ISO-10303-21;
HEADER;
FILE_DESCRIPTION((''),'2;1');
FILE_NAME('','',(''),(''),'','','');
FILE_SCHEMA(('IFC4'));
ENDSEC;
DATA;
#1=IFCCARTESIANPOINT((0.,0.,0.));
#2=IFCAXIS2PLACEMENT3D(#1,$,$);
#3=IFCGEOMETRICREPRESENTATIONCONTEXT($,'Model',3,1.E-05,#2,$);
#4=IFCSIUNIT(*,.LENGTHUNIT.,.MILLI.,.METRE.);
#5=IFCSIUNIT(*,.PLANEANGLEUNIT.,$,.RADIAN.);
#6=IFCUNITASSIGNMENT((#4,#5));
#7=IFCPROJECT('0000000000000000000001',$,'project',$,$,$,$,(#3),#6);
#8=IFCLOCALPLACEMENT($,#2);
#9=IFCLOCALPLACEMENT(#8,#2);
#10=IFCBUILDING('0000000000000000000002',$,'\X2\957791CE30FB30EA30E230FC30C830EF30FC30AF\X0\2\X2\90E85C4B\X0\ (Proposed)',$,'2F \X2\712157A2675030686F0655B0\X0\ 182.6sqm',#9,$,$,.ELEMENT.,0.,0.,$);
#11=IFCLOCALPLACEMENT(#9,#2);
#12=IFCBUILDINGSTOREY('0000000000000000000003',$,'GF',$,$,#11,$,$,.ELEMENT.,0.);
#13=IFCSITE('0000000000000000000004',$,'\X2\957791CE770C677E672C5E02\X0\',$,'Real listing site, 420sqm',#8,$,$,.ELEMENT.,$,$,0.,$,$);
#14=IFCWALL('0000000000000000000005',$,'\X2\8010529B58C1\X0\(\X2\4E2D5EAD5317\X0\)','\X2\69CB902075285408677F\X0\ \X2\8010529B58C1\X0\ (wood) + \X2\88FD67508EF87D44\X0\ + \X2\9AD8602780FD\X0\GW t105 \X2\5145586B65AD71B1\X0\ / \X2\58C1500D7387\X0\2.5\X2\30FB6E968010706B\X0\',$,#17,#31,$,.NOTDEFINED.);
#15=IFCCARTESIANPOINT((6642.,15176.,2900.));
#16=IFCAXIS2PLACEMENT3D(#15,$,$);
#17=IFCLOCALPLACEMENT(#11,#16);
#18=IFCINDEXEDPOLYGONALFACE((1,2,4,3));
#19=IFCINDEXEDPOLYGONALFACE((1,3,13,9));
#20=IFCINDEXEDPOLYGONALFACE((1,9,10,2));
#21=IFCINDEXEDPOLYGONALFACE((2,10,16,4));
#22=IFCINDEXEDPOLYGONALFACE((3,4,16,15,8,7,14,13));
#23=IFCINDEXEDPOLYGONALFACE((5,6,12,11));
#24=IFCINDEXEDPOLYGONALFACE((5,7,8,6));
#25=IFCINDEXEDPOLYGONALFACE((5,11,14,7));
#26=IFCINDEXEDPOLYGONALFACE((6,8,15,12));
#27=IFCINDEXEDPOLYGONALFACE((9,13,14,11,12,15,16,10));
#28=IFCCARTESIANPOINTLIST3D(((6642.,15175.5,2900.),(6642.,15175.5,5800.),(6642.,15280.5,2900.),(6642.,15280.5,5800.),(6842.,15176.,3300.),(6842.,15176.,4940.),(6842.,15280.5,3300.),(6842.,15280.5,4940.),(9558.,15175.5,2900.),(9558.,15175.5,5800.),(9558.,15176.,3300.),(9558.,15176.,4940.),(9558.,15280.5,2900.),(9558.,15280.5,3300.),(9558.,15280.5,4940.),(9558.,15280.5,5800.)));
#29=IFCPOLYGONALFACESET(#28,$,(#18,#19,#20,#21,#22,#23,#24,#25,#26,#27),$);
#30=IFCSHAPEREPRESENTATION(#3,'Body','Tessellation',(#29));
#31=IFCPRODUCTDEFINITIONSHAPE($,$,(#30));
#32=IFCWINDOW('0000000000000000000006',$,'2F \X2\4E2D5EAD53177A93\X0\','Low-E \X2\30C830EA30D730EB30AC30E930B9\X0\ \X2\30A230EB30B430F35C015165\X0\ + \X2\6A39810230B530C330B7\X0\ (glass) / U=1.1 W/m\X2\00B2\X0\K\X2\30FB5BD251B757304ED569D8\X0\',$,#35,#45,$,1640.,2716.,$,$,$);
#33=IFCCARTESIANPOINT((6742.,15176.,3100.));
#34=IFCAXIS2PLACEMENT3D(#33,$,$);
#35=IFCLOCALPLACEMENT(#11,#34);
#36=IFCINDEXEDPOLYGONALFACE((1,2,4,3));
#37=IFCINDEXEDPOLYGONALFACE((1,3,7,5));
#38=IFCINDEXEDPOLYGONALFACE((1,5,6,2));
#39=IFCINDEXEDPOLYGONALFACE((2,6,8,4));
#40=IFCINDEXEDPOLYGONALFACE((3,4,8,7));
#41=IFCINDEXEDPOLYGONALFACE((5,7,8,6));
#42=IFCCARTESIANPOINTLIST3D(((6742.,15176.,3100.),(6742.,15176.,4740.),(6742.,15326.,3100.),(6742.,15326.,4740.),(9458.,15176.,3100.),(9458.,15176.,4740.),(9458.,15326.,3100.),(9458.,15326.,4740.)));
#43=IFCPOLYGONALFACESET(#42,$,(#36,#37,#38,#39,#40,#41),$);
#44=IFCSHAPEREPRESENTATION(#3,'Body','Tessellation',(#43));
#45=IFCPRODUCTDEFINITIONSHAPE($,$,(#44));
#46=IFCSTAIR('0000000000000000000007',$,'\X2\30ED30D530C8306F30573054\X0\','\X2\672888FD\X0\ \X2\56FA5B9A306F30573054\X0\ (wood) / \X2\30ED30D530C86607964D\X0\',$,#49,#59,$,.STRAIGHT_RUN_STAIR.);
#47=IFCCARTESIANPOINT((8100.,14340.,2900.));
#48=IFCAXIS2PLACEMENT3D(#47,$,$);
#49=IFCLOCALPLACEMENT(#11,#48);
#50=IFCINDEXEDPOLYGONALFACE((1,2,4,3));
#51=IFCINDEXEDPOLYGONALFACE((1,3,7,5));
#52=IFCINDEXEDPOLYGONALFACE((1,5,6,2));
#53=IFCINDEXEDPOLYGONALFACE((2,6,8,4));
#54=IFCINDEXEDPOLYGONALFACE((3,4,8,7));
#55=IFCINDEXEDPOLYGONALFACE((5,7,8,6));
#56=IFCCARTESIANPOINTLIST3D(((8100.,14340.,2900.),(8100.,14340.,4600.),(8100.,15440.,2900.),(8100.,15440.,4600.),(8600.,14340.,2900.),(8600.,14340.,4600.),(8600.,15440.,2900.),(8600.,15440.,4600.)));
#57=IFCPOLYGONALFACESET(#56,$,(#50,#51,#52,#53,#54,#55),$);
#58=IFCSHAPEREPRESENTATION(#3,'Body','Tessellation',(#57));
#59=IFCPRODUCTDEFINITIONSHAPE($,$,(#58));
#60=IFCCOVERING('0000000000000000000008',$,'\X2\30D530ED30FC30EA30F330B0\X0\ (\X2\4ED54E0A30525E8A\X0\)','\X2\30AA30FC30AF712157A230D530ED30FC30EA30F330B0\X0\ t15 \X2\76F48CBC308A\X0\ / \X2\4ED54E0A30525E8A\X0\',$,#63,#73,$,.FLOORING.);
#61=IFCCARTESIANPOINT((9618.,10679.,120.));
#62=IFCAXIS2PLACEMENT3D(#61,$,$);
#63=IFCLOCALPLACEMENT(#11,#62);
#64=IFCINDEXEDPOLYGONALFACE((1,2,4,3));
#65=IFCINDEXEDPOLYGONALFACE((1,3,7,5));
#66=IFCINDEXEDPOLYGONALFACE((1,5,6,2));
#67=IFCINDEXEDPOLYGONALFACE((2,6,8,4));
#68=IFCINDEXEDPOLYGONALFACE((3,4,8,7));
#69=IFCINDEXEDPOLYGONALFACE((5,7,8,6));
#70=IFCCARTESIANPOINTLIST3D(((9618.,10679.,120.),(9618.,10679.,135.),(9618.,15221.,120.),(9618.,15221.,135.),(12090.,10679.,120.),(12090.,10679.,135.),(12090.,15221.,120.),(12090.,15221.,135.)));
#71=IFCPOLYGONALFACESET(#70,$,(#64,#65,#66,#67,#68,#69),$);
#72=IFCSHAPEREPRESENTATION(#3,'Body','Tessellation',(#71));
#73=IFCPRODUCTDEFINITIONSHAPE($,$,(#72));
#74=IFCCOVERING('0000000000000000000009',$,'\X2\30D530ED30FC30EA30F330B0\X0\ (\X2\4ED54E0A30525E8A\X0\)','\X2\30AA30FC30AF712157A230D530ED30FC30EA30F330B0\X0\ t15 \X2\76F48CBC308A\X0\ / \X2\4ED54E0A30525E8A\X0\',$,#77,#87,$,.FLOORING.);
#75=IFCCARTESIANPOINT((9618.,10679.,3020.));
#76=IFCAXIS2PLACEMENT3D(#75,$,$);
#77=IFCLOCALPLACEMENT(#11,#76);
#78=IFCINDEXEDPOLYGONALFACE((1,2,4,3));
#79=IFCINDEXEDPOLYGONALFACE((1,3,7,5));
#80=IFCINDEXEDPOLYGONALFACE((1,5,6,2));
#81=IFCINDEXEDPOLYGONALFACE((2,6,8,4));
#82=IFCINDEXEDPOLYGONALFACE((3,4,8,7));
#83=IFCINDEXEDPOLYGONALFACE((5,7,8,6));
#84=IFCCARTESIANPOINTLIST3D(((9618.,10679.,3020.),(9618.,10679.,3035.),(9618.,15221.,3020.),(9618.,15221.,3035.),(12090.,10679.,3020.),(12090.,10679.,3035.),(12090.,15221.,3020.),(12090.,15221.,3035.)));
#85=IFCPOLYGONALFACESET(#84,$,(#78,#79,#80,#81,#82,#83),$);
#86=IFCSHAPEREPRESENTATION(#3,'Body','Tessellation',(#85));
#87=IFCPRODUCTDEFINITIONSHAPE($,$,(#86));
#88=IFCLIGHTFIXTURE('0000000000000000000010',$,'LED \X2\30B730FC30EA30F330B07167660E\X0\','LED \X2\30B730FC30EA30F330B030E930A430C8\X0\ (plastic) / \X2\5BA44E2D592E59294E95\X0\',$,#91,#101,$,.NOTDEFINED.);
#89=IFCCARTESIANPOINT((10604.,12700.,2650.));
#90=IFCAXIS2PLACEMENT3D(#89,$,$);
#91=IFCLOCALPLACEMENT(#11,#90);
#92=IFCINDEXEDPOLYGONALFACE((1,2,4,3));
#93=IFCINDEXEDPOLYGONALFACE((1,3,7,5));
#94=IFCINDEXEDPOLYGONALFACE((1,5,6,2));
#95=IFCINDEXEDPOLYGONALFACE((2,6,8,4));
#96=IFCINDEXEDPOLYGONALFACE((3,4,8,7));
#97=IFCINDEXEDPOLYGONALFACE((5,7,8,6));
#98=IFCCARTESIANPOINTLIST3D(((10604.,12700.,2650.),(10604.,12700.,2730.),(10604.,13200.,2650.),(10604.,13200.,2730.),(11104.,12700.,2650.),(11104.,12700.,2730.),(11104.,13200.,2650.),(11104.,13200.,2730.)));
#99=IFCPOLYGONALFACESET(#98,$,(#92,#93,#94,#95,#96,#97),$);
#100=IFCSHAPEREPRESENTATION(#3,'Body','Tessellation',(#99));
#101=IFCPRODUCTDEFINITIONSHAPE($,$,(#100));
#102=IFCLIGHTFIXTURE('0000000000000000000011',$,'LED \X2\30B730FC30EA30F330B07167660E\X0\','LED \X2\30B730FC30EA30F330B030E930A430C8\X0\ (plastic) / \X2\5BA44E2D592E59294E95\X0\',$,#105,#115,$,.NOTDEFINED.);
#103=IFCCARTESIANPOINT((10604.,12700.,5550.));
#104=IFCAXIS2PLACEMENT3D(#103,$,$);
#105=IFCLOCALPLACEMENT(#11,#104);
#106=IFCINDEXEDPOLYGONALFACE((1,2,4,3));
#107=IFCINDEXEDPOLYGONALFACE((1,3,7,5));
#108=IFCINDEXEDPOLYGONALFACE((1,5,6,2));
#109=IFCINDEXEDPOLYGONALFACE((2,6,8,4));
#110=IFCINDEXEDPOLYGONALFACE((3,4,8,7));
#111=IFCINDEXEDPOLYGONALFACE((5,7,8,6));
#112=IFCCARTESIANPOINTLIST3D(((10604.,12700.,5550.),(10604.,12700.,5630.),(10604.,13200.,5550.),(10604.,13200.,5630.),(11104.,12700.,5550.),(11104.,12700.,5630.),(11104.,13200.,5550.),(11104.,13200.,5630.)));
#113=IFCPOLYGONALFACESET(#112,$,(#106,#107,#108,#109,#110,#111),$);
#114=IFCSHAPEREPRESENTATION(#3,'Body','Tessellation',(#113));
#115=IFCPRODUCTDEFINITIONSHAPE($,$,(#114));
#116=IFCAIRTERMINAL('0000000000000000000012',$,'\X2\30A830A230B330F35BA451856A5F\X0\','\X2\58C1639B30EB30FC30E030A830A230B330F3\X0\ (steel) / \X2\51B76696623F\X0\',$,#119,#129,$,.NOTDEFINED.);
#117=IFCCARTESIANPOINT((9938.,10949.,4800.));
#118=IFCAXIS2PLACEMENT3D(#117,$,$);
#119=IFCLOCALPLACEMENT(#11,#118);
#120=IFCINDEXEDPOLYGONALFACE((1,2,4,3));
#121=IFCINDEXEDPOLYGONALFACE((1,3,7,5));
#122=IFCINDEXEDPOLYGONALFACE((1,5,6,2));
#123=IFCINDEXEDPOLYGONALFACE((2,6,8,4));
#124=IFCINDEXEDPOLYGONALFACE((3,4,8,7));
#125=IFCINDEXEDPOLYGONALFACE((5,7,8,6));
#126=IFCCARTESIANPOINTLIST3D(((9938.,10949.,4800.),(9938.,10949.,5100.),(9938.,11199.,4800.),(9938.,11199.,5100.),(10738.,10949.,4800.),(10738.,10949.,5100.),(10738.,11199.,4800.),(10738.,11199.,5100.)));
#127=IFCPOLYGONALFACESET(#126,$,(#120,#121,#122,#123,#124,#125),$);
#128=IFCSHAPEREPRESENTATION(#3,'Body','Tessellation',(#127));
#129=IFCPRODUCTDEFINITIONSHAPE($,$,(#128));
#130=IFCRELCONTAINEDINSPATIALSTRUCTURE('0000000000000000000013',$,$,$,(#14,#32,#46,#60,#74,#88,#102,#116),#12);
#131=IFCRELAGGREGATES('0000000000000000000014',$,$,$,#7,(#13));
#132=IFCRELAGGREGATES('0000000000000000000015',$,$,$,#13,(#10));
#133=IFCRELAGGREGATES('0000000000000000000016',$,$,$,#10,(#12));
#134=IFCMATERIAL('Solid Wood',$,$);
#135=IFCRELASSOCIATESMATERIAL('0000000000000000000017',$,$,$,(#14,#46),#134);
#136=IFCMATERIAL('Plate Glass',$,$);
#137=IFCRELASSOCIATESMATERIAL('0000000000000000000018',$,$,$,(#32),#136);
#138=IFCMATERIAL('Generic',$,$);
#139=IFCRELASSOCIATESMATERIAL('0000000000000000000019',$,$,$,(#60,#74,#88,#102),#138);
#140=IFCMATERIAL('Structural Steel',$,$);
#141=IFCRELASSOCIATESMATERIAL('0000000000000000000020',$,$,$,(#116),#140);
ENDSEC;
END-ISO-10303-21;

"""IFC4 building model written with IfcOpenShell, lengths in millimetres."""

from ifc_helpers import new_model, si_unit, frame, frame_2d, origin, place, context, project, spatial, rectangle, extrude, material, element, fill, save


model = new_model("IFC4")

# Units and contexts
model_context = context("Model", 3, precision=1e-05, world=origin())
ifc_project = project(units=[si_unit("LENGTHUNIT", "METRE", prefix="MILLI"), si_unit("PLANEANGLEUNIT", "RADIAN")], contexts=[model_context])

# Site, building, storey
site_placement = place(None, origin())
site = spatial("IfcSite", under=ifc_project, at=site_placement, Name="長野県松本市", ObjectType="Real listing site, 420sqm", CompositionType="ELEMENT", RefElevation=0.0)
building_placement = place(site_placement, origin())
building = spatial("IfcBuilding", under=site, at=building_placement, Name="長野・リモートワーク2部屋 (Proposed)", ObjectType="2F 無垢材と漆喰 182.6sqm", CompositionType="ELEMENT", ElevationOfRefHeight=0.0, ElevationOfTerrain=0.0)
storey_placement = place(building_placement, origin())
storey = spatial("IfcBuildingStorey", under=building, at=storey_placement, Name="GF", CompositionType="ELEMENT", Elevation=0.0)

# Shared definitions
ifc_material_1 = material(Name="Solid Wood")
ifc_material_2 = material(Name="Structural Steel")

# Wall, opening, window
ifc_material_3 = material(Name="Plate Glass")
wall_1_placement = place(storey_placement, frame((6642.0, 15176.0, 2900.0)))
wall_1 = element("IfcWall", 1, at=wall_1_placement, inside=storey, material=ifc_material_1, Name="耐力壁(中庭北)", Description="構造用合板 耐力壁 (wood) + 製材軸組 + 高性能GW t105 充填断熱 / 壁倍率2.5・準耐火", PredefinedType="NOTDEFINED", context=model_context, shape_type="SweptSolid", body=[
    extrude(rectangle(XDim=2916.0, YDim=105.0, at=frame_2d((1458.0, 52.0))), frame((6642.0, 15176.0, 2900.0)), (0.0, 0.0, 1.0), 2900.0),
])
opening_1_placement = place(storey_placement, frame((6742.0, 15176.0, 3100.0)))
opening_1 = element("IfcOpeningElement", 2, at=opening_1_placement, cuts=wall_1, PredefinedType="NOTDEFINED", context=model_context, shape_type="SweptSolid", body=[
    extrude(rectangle(XDim=2716.0, YDim=150.0, at=frame_2d((1358.0, 75.0))), frame((6742.0, 15176.0, 3100.0)), (0.0, 0.0, 1.0), 1640.0),
])
window_1_placement = place(storey_placement, frame((6742.0, 15176.0, 3100.0)))
window_1 = element("IfcWindow", 3, at=window_1_placement, inside=storey, material=ifc_material_3, Name="2F 中庭北窓", Description="Low-E トリプルガラス アルゴン封入 + 樹脂サッシ (glass) / U=1.1 W/m²K・寒冷地仕様", OverallHeight=1640.0, OverallWidth=2716.0, context=model_context, shape_type="SweptSolid", body=[
    extrude(rectangle(XDim=2716.0, YDim=150.0, at=frame_2d((1358.0, 75.0))), frame((6742.0, 15176.0, 3100.0)), (0.0, 0.0, 1.0), 1640.0),
])
fill(opening_1, window_1)

# Stair
stair_placement = place(storey_placement, frame((8100.0, 14340.0, 2900.0)))
element("IfcStair", 4, at=stair_placement, inside=storey, material=ifc_material_1, Name="ロフトはしご", Description="木製 固定はしご (wood) / ロフト昇降", PredefinedType="STRAIGHT_RUN_STAIR", context=model_context, shape_type="SweptSolid", body=[
    extrude(rectangle(XDim=500.0, YDim=1100.0, at=frame_2d((250.0, 550.0))), frame((8100.0, 14340.0, 2900.0)), (0.0, 0.0, 1.0), 1700.0),
])

# Coverings
ifc_material_4 = material(Name="Generic")
covering_1_placement = place(storey_placement, frame((9618.0, 10679.0, 120.0)))
element("IfcCovering", 5, at=covering_1_placement, inside=storey, material=ifc_material_4, Name="フローリング (仕上げ床)", Description="オーク無垢フローリング t15 直貼り / 仕上げ床", PredefinedType="FLOORING", context=model_context, shape_type="SweptSolid", body=[
    extrude(rectangle(XDim=2472.0, YDim=4542.0, at=frame_2d((1236.0, 2271.0))), frame((9618.0, 10679.0, 120.0)), (0.0, 0.0, 1.0), 15.0),
])
covering_2_placement = place(storey_placement, frame((9618.0, 10679.0, 3020.0)))
element("IfcCovering", 6, at=covering_2_placement, inside=storey, material=ifc_material_4, Name="フローリング (仕上げ床)", Description="オーク無垢フローリング t15 直貼り / 仕上げ床", PredefinedType="FLOORING", context=model_context, shape_type="SweptSolid", body=[
    extrude(rectangle(XDim=2472.0, YDim=4542.0, at=frame_2d((1236.0, 2271.0))), frame((9618.0, 10679.0, 3020.0)), (0.0, 0.0, 1.0), 15.0),
])

# Light fixtures
light_fixture_1_placement = place(storey_placement, frame((10604.0, 12700.0, 2650.0)))
element("IfcLightFixture", 7, at=light_fixture_1_placement, inside=storey, material=ifc_material_4, Name="LED シーリング照明", Description="LED シーリングライト (plastic) / 室中央天井", PredefinedType="NOTDEFINED", context=model_context, shape_type="SweptSolid", body=[
    extrude(rectangle(XDim=500.0, YDim=500.0, at=frame_2d((250.0, 250.0))), frame((10604.0, 12700.0, 2650.0)), (0.0, 0.0, 1.0), 80.0),
])
light_fixture_2_placement = place(storey_placement, frame((10604.0, 12700.0, 5550.0)))
element("IfcLightFixture", 8, at=light_fixture_2_placement, inside=storey, material=ifc_material_4, Name="LED シーリング照明", Description="LED シーリングライト (plastic) / 室中央天井", PredefinedType="NOTDEFINED", context=model_context, shape_type="SweptSolid", body=[
    extrude(rectangle(XDim=500.0, YDim=500.0, at=frame_2d((250.0, 250.0))), frame((10604.0, 12700.0, 5550.0)), (0.0, 0.0, 1.0), 80.0),
])

# Air terminal
air_terminal_placement = place(storey_placement, frame((9938.0, 10949.0, 4800.0)))
element("IfcAirTerminal", 9, at=air_terminal_placement, inside=storey, material=ifc_material_2, Name="エアコン室内機", Description="壁掛ルームエアコン (steel) / 冷暖房", PredefinedType="NOTDEFINED", context=model_context, shape_type="SweptSolid", body=[
    extrude(rectangle(XDim=800.0, YDim=250.0, at=frame_2d((400.0, 125.0))), frame((9938.0, 10949.0, 4800.0)), (0.0, 0.0, 1.0), 300.0),
])

save(model, "model.ifc")
